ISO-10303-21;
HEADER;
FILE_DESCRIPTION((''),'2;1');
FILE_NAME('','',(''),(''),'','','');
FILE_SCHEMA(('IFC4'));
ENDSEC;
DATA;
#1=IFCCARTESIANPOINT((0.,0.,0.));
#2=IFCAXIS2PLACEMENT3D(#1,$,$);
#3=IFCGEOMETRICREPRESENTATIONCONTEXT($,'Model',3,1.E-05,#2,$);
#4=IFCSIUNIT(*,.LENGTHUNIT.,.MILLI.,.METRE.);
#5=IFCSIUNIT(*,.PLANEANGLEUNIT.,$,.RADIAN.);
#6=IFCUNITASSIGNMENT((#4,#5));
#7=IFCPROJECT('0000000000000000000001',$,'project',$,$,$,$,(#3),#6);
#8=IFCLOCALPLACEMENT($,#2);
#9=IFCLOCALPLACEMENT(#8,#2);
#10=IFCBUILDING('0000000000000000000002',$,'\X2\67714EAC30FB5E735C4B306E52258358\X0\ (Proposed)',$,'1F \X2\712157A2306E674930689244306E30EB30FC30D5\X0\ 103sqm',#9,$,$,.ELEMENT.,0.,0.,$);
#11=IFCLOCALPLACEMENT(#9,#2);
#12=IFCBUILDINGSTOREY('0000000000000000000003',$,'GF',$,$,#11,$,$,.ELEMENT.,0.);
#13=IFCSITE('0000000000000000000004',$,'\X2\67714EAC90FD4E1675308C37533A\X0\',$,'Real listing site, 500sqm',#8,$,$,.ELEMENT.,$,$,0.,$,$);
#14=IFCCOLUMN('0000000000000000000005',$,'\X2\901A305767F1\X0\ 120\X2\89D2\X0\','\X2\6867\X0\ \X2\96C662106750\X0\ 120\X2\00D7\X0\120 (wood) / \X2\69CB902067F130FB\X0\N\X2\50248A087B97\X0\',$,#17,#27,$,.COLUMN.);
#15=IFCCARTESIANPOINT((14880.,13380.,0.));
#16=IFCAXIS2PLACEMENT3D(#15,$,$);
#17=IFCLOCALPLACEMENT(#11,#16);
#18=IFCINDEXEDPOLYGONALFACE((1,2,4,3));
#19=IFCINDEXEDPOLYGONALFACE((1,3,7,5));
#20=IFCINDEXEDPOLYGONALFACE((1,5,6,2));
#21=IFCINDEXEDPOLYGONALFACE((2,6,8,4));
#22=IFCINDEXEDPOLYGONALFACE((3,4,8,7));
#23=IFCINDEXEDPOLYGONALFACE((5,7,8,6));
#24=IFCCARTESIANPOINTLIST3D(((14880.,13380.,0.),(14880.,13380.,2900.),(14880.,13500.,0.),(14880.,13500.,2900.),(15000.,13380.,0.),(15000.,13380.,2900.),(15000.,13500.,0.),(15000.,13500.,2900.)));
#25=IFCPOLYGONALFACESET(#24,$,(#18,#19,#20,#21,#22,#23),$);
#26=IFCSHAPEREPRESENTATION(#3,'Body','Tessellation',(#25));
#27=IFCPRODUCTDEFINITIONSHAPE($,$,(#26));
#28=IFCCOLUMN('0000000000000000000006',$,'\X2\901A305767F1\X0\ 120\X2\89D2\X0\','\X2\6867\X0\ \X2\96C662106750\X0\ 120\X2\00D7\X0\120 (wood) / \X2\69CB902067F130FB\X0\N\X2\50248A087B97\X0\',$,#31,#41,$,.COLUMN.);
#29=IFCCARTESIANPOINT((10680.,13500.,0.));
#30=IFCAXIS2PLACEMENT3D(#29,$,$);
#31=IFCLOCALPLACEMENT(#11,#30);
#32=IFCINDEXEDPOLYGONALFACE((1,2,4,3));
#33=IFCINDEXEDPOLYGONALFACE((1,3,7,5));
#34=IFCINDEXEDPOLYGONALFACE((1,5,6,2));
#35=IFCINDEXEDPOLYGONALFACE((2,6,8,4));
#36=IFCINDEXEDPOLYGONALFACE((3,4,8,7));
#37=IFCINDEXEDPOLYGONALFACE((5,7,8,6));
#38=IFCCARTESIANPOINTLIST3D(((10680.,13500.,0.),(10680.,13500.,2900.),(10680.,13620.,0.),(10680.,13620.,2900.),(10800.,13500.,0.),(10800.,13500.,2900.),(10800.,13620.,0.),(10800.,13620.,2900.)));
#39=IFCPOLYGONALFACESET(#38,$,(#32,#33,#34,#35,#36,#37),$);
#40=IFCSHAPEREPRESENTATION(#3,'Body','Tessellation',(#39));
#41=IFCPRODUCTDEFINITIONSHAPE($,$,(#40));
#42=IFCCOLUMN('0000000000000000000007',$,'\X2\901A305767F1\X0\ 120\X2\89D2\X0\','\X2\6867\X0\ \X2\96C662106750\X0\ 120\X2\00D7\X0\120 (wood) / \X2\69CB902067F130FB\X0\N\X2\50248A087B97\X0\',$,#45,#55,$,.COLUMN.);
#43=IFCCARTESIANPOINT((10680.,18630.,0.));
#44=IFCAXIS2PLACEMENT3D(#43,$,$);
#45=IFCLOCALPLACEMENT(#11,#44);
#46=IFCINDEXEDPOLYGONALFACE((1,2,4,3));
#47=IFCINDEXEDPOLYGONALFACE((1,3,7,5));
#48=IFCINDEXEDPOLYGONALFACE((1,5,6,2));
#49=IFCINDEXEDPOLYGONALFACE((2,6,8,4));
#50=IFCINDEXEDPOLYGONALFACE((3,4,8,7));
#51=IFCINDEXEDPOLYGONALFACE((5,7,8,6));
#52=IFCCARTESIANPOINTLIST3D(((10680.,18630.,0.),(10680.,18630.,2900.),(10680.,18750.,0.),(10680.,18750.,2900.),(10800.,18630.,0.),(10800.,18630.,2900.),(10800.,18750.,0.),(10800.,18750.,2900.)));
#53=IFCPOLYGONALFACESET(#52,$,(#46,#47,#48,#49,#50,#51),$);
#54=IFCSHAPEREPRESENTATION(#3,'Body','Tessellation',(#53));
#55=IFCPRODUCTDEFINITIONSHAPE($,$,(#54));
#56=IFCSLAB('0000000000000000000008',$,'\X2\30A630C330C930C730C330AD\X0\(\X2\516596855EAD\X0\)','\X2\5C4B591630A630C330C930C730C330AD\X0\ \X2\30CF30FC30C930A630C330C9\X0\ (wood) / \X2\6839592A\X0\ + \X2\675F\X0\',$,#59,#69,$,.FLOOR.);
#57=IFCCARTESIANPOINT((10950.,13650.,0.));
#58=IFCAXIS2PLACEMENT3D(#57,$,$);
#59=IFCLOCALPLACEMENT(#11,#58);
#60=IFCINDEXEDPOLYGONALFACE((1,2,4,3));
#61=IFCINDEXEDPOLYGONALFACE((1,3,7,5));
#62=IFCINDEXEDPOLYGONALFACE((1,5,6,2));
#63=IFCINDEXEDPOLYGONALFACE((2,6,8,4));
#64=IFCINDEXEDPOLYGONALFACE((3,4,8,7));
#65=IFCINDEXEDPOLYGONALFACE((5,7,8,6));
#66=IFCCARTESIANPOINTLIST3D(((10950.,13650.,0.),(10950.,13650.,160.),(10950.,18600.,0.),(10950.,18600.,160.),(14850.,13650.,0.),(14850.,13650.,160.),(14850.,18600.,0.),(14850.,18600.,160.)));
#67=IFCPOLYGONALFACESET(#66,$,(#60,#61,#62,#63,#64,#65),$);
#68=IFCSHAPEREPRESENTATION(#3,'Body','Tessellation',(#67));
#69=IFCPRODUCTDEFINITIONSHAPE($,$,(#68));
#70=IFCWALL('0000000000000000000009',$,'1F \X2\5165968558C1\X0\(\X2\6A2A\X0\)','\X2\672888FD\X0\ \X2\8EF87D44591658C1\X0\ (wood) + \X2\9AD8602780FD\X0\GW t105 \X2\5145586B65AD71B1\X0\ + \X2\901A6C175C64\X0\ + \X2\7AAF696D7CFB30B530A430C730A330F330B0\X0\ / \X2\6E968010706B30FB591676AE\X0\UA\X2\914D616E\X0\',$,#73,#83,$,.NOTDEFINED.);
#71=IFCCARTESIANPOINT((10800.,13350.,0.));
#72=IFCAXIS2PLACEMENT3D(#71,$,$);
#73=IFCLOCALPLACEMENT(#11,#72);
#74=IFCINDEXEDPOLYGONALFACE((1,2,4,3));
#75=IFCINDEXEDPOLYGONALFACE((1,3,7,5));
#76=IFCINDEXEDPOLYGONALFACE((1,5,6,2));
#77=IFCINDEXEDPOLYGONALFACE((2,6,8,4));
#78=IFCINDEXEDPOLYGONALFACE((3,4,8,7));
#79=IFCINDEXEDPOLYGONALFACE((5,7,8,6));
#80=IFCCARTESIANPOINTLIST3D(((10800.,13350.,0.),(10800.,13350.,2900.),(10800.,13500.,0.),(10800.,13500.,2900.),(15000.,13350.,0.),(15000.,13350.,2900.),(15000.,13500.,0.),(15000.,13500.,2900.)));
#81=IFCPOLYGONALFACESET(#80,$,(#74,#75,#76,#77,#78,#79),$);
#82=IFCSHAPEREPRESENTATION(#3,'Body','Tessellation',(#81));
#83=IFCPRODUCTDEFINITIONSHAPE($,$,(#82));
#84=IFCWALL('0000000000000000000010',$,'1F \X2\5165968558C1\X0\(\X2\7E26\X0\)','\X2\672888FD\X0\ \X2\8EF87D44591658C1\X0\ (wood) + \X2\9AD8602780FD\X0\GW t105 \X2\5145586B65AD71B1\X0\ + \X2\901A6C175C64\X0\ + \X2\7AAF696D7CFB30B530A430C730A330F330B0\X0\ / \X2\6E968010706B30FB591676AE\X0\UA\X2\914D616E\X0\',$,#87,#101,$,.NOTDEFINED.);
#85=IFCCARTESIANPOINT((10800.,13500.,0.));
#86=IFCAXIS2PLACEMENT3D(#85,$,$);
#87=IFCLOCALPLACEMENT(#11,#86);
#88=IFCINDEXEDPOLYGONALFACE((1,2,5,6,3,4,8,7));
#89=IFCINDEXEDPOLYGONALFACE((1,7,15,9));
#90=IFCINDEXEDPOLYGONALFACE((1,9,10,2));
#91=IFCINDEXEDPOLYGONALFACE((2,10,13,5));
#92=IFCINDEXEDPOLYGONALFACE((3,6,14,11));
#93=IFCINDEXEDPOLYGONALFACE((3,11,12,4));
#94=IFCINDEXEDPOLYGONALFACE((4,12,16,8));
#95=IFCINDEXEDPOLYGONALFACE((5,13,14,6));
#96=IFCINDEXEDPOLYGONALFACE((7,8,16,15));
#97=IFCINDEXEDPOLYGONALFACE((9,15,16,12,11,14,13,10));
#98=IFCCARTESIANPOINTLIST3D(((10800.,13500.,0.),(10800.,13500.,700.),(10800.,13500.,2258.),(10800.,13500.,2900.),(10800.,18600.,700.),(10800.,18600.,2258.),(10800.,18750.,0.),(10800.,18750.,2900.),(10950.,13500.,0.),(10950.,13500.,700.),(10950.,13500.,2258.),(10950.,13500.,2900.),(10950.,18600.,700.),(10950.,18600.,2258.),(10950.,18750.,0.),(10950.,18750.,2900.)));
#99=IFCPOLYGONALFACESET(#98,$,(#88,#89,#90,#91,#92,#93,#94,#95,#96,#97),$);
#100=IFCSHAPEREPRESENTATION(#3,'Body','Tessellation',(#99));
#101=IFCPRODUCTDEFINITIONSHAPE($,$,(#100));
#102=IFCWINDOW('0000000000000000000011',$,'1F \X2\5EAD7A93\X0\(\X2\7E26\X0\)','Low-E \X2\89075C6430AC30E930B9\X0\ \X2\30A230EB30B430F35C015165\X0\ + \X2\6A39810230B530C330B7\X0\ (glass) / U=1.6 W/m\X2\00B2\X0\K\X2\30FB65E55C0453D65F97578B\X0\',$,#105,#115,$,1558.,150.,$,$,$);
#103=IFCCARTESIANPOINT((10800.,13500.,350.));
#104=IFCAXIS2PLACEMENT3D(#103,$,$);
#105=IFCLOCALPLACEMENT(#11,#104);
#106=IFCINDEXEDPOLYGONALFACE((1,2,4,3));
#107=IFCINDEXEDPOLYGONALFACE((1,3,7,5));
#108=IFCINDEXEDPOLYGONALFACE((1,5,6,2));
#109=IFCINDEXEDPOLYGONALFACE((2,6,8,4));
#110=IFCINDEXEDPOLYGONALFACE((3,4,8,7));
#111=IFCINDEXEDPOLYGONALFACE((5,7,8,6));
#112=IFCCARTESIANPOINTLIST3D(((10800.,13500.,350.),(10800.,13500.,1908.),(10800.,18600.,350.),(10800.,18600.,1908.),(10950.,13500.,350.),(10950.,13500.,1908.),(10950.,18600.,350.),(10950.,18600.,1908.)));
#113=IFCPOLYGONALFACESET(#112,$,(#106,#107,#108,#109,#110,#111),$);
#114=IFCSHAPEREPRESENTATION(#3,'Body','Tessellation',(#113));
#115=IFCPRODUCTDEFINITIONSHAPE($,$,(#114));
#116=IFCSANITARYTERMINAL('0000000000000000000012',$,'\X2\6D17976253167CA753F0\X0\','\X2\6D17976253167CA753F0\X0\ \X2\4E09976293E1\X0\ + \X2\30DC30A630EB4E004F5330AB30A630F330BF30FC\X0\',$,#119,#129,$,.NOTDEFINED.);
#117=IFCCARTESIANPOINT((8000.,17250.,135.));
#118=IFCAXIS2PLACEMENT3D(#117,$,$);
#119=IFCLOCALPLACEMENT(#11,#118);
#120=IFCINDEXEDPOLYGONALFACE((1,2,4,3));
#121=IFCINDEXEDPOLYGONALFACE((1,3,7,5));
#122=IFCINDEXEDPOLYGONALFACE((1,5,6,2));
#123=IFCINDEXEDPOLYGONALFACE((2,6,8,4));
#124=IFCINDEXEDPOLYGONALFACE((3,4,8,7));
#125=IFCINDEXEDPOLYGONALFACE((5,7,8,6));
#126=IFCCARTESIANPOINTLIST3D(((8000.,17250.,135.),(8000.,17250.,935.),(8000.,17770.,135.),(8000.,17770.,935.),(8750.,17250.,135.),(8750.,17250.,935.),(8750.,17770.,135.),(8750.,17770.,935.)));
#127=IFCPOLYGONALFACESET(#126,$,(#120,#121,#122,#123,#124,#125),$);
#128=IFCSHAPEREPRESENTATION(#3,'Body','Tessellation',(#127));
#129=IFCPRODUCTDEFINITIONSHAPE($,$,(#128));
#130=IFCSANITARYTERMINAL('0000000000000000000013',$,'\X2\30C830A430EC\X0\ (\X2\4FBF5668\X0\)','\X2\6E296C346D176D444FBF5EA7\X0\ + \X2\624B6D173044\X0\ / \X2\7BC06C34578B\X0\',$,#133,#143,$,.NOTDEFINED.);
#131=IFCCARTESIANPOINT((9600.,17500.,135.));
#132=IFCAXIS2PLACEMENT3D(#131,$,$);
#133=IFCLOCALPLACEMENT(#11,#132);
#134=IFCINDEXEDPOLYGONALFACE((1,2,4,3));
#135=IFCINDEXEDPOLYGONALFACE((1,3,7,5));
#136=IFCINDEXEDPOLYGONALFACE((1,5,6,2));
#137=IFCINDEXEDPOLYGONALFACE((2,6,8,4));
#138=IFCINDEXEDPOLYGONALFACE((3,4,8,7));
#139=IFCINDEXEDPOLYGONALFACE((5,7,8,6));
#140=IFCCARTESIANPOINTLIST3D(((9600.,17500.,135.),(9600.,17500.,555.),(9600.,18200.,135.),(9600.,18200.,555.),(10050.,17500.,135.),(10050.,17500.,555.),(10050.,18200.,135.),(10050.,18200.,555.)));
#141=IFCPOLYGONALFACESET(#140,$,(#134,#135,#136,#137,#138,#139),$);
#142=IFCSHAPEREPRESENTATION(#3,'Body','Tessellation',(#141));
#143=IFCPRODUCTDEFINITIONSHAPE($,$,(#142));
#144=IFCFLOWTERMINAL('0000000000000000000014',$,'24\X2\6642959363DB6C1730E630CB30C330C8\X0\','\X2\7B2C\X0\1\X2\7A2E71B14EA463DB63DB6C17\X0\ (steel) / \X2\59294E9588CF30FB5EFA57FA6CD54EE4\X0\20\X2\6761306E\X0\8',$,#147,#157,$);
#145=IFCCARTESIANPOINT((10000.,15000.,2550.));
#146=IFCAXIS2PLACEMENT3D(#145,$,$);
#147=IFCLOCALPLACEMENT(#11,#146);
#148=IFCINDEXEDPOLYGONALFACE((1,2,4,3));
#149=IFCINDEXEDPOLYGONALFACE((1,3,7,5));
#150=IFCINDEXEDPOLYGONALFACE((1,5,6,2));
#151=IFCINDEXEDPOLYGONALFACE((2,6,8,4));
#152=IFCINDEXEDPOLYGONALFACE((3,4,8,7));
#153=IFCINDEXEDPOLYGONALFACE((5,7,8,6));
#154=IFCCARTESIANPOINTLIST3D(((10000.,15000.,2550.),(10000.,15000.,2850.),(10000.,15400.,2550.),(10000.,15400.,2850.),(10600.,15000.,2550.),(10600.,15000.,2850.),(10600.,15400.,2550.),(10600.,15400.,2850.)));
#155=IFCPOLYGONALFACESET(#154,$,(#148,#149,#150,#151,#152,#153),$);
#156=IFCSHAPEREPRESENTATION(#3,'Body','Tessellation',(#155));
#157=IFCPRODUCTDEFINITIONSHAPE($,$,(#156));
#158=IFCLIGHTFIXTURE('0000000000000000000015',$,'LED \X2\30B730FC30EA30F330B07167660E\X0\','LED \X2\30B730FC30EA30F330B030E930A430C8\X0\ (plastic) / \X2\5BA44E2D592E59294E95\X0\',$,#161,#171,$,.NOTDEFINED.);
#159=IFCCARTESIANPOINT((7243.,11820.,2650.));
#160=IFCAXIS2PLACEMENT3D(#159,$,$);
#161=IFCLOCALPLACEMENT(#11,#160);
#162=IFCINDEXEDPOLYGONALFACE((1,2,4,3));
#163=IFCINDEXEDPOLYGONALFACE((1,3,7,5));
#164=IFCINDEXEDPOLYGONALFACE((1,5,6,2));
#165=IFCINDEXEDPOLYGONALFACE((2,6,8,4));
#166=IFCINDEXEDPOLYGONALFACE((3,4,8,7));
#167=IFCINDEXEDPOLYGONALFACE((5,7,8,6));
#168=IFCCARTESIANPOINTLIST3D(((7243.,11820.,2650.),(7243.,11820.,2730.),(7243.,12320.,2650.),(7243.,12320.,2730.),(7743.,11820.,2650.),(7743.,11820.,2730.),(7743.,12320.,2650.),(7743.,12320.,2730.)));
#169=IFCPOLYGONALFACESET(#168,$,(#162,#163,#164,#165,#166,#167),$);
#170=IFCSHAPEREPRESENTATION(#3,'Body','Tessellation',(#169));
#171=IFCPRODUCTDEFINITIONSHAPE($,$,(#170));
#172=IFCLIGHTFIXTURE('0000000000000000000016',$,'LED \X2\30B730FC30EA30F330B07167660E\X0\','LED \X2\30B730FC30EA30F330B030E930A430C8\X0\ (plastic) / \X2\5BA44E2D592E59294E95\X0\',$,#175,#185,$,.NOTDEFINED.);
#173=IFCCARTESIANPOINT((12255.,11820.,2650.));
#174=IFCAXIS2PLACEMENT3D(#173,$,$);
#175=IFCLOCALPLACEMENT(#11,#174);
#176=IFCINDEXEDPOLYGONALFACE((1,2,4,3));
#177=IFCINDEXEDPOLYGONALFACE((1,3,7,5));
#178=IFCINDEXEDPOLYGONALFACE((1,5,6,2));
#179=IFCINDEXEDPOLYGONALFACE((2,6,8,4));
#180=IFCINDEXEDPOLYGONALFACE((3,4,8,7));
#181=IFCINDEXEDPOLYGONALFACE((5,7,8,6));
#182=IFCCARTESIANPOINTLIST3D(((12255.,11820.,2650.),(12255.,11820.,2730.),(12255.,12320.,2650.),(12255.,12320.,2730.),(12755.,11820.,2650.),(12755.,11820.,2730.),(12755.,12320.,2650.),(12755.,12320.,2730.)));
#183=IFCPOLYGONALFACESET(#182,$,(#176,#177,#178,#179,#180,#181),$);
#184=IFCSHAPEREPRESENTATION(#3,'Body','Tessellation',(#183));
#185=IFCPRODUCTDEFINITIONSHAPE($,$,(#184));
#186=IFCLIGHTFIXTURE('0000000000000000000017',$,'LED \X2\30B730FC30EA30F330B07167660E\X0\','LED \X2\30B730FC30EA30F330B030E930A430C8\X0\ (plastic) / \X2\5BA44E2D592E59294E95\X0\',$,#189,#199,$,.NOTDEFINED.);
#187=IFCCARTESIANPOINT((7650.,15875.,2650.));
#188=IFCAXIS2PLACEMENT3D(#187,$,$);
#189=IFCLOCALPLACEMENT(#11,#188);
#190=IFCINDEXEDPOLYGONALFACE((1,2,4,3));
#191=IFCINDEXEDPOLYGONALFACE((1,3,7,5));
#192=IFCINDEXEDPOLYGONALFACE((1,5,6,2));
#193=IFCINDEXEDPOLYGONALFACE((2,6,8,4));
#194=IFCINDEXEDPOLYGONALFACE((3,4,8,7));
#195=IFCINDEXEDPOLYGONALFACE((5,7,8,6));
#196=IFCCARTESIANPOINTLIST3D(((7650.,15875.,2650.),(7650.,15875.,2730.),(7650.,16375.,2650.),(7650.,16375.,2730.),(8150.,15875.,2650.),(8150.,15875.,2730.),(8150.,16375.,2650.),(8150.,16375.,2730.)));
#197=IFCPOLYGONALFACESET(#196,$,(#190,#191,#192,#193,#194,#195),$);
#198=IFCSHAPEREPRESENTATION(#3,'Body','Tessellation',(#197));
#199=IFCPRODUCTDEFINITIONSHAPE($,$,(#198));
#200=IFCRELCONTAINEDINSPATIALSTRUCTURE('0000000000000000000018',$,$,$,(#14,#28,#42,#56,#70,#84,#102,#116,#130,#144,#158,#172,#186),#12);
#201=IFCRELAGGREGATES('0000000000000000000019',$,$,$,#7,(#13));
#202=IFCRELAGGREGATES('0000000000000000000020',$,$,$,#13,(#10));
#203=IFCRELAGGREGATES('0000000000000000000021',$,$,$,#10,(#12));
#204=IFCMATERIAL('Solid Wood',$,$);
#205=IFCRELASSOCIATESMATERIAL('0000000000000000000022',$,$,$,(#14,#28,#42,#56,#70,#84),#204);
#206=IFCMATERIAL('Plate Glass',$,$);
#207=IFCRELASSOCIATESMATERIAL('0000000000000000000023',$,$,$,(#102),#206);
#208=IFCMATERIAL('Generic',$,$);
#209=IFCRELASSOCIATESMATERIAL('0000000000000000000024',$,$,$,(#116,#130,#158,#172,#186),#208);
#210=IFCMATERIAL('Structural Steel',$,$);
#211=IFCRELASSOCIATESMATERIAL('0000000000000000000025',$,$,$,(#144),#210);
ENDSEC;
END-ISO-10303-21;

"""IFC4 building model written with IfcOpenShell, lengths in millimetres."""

from ifc_helpers import new_model, si_unit, frame, frame_2d, origin, place, context, project, spatial, rectangle, extrude, material, element, fill, save


model = new_model("IFC4")

# Units and contexts
model_context = context("Model", 3, precision=1e-05, world=origin())
ifc_project = project(units=[si_unit("LENGTHUNIT", "METRE", prefix="MILLI"), si_unit("PLANEANGLEUNIT", "RADIAN")], contexts=[model_context])

# Site, building, storey
site_placement = place(None, origin())
site = spatial("IfcSite", under=ifc_project, at=site_placement, Name="東京都世田谷区", ObjectType="Real listing site, 500sqm", CompositionType="ELEMENT", RefElevation=0.0)
building_placement = place(site_placement, origin())
building = spatial("IfcBuilding", under=site, at=building_placement, Name="東京・平屋の別荘 (Proposed)", ObjectType="1F 無垢の杉と鉄のルーフ 103sqm", CompositionType="ELEMENT", ElevationOfRefHeight=0.0, ElevationOfTerrain=0.0)
storey_placement = place(building_placement, origin())
storey = spatial("IfcBuildingStorey", under=building, at=storey_placement, Name="GF", CompositionType="ELEMENT", Elevation=0.0)

# Columns
ifc_material_1 = material(Name="Solid Wood")
column_1_placement = place(storey_placement, frame((14880.0, 13380.0, 0.0)))
element("IfcColumn", 1, at=column_1_placement, inside=storey, material=ifc_material_1, Name="通し柱 120角", Description="桧 集成材 120×120 (wood) / 構造柱・N値計算", PredefinedType="COLUMN", context=model_context, shape_type="SweptSolid", body=[
    extrude(rectangle(XDim=120.0, YDim=120.0, at=frame_2d((60.0, 60.0))), frame((14880.0, 13380.0, 0.0)), (0.0, 0.0, 1.0), 2900.0),
])
column_2_placement = place(storey_placement, frame((10680.0, 13500.0, 0.0)))
element("IfcColumn", 2, at=column_2_placement, inside=storey, material=ifc_material_1, Name="通し柱 120角", Description="桧 集成材 120×120 (wood) / 構造柱・N値計算", PredefinedType="COLUMN", context=model_context, shape_type="SweptSolid", body=[
    extrude(rectangle(XDim=120.0, YDim=120.0, at=frame_2d((60.0, 60.0))), frame((10680.0, 13500.0, 0.0)), (0.0, 0.0, 1.0), 2900.0),
])
column_3_placement = place(storey_placement, frame((10680.0, 18630.0, 0.0)))
element("IfcColumn", 3, at=column_3_placement, inside=storey, material=ifc_material_1, Name="通し柱 120角", Description="桧 集成材 120×120 (wood) / 構造柱・N値計算", PredefinedType="COLUMN", context=model_context, shape_type="SweptSolid", body=[
    extrude(rectangle(XDim=120.0, YDim=120.0, at=frame_2d((60.0, 60.0))), frame((10680.0, 18630.0, 0.0)), (0.0, 0.0, 1.0), 2900.0),
])

# Slab
slab_placement = place(storey_placement, frame((10950.0, 13650.0, 0.0)))
element("IfcSlab", 4, at=slab_placement, inside=storey, material=ifc_material_1, Name="ウッドデッキ(入隅庭)", Description="屋外ウッドデッキ ハードウッド (wood) / 根太 + 束", PredefinedType="FLOOR", context=model_context, shape_type="SweptSolid", body=[
    extrude(rectangle(XDim=3900.0, YDim=4950.0, at=frame_2d((1950.0, 2475.0))), frame((10950.0, 13650.0, 0.0)), (0.0, 0.0, 1.0), 160.0),
])

# Wall
wall_1_placement = place(storey_placement, frame((10800.0, 13350.0, 0.0)))
element("IfcWall", 5, at=wall_1_placement, inside=storey, material=ifc_material_1, Name="1F 入隅壁(横)", Description="木製 軸組外壁 (wood) + 高性能GW t105 充填断熱 + 通気層 + 窯業系サイディング / 準耐火・外皮UA配慮", PredefinedType="NOTDEFINED", context=model_context, shape_type="SweptSolid", body=[
    extrude(rectangle(XDim=4200.0, YDim=150.0, at=frame_2d((2100.0, 75.0))), frame((10800.0, 13350.0, 0.0)), (0.0, 0.0, 1.0), 2900.0),
])

# Wall, opening, window
wall_2_placement = place(storey_placement, frame((10800.0, 13500.0, 0.0)))
wall_2 = element("IfcWall", 6, at=wall_2_placement, inside=storey, material=ifc_material_1, Name="1F 入隅壁(縦)", Description="木製 軸組外壁 (wood) + 高性能GW t105 充填断熱 + 通気層 + 窯業系サイディング / 準耐火・外皮UA配慮", PredefinedType="NOTDEFINED", context=model_context, shape_type="SweptSolid", body=[
    extrude(rectangle(XDim=150.0, YDim=5250.0, at=frame_2d((75.0, 2625.0))), frame((10800.0, 13500.0, 0.0)), (0.0, 0.0, 1.0), 2900.0),
])
opening_placement = place(storey_placement, frame((10800.0, 13500.0, 350.0)))
opening = element("IfcOpeningElement", 7, at=opening_placement, cuts=wall_2, PredefinedType="NOTDEFINED", context=model_context, shape_type="SweptSolid", body=[
    extrude(rectangle(XDim=150.0, YDim=5100.0, at=frame_2d((75.0, 2550.0))), frame((10800.0, 13500.0, 350.0)), (0.0, 0.0, 1.0), 1558.0),
])
ifc_material_2 = material(Name="Plate Glass")
window_placement = place(storey_placement, frame((10800.0, 13500.0, 350.0)))
window = element("IfcWindow", 8, at=window_placement, inside=storey, material=ifc_material_2, Name="1F 庭窓(縦)", Description="Low-E 複層ガラス アルゴン封入 + 樹脂サッシ (glass) / U=1.6 W/m²K・日射取得型", OverallHeight=1558.0, OverallWidth=150.0, context=model_context, shape_type="SweptSolid", body=[
    extrude(rectangle(XDim=150.0, YDim=5100.0, at=frame_2d((75.0, 2550.0))), frame((10800.0, 13500.0, 350.0)), (0.0, 0.0, 1.0), 1558.0),
])
fill(opening, window)

# Sanitary terminals
ifc_material_3 = material(Name="Generic")
sanitary_terminal_1_placement = place(storey_placement, frame((8000.0, 17250.0, 135.0)))
element("IfcSanitaryTerminal", 9, at=sanitary_terminal_1_placement, inside=storey, material=ifc_material_3, Name="洗面化粧台", Description="洗面化粧台 三面鏡 + ボウル一体カウンター", PredefinedType="NOTDEFINED", context=model_context, shape_type="SweptSolid", body=[
    extrude(rectangle(XDim=750.0, YDim=520.0, at=frame_2d((375.0, 260.0))), frame((8000.0, 17250.0, 135.0)), (0.0, 0.0, 1.0), 800.0),
])
sanitary_terminal_2_placement = place(storey_placement, frame((9600.0, 17500.0, 135.0)))
element("IfcSanitaryTerminal", 10, at=sanitary_terminal_2_placement, inside=storey, material=ifc_material_3, Name="トイレ (便器)", Description="温水洗浄便座 + 手洗い / 節水型", PredefinedType="NOTDEFINED", context=model_context, shape_type="SweptSolid", body=[
    extrude(rectangle(XDim=450.0, YDim=700.0, at=frame_2d((225.0, 350.0))), frame((9600.0, 17500.0, 135.0)), (0.0, 0.0, 1.0), 420.0),
])

# Flow terminal
ifc_material_4 = material(Name="Structural Steel")
flow_terminal_placement = place(storey_placement, frame((10000.0, 15000.0, 2550.0)))
element("IfcFlowTerminal", 11, at=flow_terminal_placement, inside=storey, material=ifc_material_4, Name="24時間換気ユニット", Description="第1種熱交換換気 (steel) / 天井裏・建基法令20条の8", context=model_context, shape_type="SweptSolid", body=[
    extrude(rectangle(XDim=600.0, YDim=400.0, at=frame_2d((300.0, 200.0))), frame((10000.0, 15000.0, 2550.0)), (0.0, 0.0, 1.0), 300.0),
])

# Light fixtures
light_fixture_1_placement = place(storey_placement, frame((7243.0, 11820.0, 2650.0)))
element("IfcLightFixture", 12, at=light_fixture_1_placement, inside=storey, material=ifc_material_3, Name="LED シーリング照明", Description="LED シーリングライト (plastic) / 室中央天井", PredefinedType="NOTDEFINED", context=model_context, shape_type="SweptSolid", body=[
    extrude(rectangle(XDim=500.0, YDim=500.0, at=frame_2d((250.0, 250.0))), frame((7243.0, 11820.0, 2650.0)), (0.0, 0.0, 1.0), 80.0),
])
light_fixture_2_placement = place(storey_placement, frame((12255.0, 11820.0, 2650.0)))
element("IfcLightFixture", 13, at=light_fixture_2_placement, inside=storey, material=ifc_material_3, Name="LED シーリング照明", Description="LED シーリングライト (plastic) / 室中央天井", PredefinedType="NOTDEFINED", context=model_context, shape_type="SweptSolid", body=[
    extrude(rectangle(XDim=500.0, YDim=500.0, at=frame_2d((250.0, 250.0))), frame((12255.0, 11820.0, 2650.0)), (0.0, 0.0, 1.0), 80.0),
])
light_fixture_3_placement = place(storey_placement, frame((7650.0, 15875.0, 2650.0)))
element("IfcLightFixture", 14, at=light_fixture_3_placement, inside=storey, material=ifc_material_3, Name="LED シーリング照明", Description="LED シーリングライト (plastic) / 室中央天井", PredefinedType="NOTDEFINED", context=model_context, shape_type="SweptSolid", body=[
    extrude(rectangle(XDim=500.0, YDim=500.0, at=frame_2d((250.0, 250.0))), frame((7650.0, 15875.0, 2650.0)), (0.0, 0.0, 1.0), 80.0),
])

save(model, "model.ifc")
